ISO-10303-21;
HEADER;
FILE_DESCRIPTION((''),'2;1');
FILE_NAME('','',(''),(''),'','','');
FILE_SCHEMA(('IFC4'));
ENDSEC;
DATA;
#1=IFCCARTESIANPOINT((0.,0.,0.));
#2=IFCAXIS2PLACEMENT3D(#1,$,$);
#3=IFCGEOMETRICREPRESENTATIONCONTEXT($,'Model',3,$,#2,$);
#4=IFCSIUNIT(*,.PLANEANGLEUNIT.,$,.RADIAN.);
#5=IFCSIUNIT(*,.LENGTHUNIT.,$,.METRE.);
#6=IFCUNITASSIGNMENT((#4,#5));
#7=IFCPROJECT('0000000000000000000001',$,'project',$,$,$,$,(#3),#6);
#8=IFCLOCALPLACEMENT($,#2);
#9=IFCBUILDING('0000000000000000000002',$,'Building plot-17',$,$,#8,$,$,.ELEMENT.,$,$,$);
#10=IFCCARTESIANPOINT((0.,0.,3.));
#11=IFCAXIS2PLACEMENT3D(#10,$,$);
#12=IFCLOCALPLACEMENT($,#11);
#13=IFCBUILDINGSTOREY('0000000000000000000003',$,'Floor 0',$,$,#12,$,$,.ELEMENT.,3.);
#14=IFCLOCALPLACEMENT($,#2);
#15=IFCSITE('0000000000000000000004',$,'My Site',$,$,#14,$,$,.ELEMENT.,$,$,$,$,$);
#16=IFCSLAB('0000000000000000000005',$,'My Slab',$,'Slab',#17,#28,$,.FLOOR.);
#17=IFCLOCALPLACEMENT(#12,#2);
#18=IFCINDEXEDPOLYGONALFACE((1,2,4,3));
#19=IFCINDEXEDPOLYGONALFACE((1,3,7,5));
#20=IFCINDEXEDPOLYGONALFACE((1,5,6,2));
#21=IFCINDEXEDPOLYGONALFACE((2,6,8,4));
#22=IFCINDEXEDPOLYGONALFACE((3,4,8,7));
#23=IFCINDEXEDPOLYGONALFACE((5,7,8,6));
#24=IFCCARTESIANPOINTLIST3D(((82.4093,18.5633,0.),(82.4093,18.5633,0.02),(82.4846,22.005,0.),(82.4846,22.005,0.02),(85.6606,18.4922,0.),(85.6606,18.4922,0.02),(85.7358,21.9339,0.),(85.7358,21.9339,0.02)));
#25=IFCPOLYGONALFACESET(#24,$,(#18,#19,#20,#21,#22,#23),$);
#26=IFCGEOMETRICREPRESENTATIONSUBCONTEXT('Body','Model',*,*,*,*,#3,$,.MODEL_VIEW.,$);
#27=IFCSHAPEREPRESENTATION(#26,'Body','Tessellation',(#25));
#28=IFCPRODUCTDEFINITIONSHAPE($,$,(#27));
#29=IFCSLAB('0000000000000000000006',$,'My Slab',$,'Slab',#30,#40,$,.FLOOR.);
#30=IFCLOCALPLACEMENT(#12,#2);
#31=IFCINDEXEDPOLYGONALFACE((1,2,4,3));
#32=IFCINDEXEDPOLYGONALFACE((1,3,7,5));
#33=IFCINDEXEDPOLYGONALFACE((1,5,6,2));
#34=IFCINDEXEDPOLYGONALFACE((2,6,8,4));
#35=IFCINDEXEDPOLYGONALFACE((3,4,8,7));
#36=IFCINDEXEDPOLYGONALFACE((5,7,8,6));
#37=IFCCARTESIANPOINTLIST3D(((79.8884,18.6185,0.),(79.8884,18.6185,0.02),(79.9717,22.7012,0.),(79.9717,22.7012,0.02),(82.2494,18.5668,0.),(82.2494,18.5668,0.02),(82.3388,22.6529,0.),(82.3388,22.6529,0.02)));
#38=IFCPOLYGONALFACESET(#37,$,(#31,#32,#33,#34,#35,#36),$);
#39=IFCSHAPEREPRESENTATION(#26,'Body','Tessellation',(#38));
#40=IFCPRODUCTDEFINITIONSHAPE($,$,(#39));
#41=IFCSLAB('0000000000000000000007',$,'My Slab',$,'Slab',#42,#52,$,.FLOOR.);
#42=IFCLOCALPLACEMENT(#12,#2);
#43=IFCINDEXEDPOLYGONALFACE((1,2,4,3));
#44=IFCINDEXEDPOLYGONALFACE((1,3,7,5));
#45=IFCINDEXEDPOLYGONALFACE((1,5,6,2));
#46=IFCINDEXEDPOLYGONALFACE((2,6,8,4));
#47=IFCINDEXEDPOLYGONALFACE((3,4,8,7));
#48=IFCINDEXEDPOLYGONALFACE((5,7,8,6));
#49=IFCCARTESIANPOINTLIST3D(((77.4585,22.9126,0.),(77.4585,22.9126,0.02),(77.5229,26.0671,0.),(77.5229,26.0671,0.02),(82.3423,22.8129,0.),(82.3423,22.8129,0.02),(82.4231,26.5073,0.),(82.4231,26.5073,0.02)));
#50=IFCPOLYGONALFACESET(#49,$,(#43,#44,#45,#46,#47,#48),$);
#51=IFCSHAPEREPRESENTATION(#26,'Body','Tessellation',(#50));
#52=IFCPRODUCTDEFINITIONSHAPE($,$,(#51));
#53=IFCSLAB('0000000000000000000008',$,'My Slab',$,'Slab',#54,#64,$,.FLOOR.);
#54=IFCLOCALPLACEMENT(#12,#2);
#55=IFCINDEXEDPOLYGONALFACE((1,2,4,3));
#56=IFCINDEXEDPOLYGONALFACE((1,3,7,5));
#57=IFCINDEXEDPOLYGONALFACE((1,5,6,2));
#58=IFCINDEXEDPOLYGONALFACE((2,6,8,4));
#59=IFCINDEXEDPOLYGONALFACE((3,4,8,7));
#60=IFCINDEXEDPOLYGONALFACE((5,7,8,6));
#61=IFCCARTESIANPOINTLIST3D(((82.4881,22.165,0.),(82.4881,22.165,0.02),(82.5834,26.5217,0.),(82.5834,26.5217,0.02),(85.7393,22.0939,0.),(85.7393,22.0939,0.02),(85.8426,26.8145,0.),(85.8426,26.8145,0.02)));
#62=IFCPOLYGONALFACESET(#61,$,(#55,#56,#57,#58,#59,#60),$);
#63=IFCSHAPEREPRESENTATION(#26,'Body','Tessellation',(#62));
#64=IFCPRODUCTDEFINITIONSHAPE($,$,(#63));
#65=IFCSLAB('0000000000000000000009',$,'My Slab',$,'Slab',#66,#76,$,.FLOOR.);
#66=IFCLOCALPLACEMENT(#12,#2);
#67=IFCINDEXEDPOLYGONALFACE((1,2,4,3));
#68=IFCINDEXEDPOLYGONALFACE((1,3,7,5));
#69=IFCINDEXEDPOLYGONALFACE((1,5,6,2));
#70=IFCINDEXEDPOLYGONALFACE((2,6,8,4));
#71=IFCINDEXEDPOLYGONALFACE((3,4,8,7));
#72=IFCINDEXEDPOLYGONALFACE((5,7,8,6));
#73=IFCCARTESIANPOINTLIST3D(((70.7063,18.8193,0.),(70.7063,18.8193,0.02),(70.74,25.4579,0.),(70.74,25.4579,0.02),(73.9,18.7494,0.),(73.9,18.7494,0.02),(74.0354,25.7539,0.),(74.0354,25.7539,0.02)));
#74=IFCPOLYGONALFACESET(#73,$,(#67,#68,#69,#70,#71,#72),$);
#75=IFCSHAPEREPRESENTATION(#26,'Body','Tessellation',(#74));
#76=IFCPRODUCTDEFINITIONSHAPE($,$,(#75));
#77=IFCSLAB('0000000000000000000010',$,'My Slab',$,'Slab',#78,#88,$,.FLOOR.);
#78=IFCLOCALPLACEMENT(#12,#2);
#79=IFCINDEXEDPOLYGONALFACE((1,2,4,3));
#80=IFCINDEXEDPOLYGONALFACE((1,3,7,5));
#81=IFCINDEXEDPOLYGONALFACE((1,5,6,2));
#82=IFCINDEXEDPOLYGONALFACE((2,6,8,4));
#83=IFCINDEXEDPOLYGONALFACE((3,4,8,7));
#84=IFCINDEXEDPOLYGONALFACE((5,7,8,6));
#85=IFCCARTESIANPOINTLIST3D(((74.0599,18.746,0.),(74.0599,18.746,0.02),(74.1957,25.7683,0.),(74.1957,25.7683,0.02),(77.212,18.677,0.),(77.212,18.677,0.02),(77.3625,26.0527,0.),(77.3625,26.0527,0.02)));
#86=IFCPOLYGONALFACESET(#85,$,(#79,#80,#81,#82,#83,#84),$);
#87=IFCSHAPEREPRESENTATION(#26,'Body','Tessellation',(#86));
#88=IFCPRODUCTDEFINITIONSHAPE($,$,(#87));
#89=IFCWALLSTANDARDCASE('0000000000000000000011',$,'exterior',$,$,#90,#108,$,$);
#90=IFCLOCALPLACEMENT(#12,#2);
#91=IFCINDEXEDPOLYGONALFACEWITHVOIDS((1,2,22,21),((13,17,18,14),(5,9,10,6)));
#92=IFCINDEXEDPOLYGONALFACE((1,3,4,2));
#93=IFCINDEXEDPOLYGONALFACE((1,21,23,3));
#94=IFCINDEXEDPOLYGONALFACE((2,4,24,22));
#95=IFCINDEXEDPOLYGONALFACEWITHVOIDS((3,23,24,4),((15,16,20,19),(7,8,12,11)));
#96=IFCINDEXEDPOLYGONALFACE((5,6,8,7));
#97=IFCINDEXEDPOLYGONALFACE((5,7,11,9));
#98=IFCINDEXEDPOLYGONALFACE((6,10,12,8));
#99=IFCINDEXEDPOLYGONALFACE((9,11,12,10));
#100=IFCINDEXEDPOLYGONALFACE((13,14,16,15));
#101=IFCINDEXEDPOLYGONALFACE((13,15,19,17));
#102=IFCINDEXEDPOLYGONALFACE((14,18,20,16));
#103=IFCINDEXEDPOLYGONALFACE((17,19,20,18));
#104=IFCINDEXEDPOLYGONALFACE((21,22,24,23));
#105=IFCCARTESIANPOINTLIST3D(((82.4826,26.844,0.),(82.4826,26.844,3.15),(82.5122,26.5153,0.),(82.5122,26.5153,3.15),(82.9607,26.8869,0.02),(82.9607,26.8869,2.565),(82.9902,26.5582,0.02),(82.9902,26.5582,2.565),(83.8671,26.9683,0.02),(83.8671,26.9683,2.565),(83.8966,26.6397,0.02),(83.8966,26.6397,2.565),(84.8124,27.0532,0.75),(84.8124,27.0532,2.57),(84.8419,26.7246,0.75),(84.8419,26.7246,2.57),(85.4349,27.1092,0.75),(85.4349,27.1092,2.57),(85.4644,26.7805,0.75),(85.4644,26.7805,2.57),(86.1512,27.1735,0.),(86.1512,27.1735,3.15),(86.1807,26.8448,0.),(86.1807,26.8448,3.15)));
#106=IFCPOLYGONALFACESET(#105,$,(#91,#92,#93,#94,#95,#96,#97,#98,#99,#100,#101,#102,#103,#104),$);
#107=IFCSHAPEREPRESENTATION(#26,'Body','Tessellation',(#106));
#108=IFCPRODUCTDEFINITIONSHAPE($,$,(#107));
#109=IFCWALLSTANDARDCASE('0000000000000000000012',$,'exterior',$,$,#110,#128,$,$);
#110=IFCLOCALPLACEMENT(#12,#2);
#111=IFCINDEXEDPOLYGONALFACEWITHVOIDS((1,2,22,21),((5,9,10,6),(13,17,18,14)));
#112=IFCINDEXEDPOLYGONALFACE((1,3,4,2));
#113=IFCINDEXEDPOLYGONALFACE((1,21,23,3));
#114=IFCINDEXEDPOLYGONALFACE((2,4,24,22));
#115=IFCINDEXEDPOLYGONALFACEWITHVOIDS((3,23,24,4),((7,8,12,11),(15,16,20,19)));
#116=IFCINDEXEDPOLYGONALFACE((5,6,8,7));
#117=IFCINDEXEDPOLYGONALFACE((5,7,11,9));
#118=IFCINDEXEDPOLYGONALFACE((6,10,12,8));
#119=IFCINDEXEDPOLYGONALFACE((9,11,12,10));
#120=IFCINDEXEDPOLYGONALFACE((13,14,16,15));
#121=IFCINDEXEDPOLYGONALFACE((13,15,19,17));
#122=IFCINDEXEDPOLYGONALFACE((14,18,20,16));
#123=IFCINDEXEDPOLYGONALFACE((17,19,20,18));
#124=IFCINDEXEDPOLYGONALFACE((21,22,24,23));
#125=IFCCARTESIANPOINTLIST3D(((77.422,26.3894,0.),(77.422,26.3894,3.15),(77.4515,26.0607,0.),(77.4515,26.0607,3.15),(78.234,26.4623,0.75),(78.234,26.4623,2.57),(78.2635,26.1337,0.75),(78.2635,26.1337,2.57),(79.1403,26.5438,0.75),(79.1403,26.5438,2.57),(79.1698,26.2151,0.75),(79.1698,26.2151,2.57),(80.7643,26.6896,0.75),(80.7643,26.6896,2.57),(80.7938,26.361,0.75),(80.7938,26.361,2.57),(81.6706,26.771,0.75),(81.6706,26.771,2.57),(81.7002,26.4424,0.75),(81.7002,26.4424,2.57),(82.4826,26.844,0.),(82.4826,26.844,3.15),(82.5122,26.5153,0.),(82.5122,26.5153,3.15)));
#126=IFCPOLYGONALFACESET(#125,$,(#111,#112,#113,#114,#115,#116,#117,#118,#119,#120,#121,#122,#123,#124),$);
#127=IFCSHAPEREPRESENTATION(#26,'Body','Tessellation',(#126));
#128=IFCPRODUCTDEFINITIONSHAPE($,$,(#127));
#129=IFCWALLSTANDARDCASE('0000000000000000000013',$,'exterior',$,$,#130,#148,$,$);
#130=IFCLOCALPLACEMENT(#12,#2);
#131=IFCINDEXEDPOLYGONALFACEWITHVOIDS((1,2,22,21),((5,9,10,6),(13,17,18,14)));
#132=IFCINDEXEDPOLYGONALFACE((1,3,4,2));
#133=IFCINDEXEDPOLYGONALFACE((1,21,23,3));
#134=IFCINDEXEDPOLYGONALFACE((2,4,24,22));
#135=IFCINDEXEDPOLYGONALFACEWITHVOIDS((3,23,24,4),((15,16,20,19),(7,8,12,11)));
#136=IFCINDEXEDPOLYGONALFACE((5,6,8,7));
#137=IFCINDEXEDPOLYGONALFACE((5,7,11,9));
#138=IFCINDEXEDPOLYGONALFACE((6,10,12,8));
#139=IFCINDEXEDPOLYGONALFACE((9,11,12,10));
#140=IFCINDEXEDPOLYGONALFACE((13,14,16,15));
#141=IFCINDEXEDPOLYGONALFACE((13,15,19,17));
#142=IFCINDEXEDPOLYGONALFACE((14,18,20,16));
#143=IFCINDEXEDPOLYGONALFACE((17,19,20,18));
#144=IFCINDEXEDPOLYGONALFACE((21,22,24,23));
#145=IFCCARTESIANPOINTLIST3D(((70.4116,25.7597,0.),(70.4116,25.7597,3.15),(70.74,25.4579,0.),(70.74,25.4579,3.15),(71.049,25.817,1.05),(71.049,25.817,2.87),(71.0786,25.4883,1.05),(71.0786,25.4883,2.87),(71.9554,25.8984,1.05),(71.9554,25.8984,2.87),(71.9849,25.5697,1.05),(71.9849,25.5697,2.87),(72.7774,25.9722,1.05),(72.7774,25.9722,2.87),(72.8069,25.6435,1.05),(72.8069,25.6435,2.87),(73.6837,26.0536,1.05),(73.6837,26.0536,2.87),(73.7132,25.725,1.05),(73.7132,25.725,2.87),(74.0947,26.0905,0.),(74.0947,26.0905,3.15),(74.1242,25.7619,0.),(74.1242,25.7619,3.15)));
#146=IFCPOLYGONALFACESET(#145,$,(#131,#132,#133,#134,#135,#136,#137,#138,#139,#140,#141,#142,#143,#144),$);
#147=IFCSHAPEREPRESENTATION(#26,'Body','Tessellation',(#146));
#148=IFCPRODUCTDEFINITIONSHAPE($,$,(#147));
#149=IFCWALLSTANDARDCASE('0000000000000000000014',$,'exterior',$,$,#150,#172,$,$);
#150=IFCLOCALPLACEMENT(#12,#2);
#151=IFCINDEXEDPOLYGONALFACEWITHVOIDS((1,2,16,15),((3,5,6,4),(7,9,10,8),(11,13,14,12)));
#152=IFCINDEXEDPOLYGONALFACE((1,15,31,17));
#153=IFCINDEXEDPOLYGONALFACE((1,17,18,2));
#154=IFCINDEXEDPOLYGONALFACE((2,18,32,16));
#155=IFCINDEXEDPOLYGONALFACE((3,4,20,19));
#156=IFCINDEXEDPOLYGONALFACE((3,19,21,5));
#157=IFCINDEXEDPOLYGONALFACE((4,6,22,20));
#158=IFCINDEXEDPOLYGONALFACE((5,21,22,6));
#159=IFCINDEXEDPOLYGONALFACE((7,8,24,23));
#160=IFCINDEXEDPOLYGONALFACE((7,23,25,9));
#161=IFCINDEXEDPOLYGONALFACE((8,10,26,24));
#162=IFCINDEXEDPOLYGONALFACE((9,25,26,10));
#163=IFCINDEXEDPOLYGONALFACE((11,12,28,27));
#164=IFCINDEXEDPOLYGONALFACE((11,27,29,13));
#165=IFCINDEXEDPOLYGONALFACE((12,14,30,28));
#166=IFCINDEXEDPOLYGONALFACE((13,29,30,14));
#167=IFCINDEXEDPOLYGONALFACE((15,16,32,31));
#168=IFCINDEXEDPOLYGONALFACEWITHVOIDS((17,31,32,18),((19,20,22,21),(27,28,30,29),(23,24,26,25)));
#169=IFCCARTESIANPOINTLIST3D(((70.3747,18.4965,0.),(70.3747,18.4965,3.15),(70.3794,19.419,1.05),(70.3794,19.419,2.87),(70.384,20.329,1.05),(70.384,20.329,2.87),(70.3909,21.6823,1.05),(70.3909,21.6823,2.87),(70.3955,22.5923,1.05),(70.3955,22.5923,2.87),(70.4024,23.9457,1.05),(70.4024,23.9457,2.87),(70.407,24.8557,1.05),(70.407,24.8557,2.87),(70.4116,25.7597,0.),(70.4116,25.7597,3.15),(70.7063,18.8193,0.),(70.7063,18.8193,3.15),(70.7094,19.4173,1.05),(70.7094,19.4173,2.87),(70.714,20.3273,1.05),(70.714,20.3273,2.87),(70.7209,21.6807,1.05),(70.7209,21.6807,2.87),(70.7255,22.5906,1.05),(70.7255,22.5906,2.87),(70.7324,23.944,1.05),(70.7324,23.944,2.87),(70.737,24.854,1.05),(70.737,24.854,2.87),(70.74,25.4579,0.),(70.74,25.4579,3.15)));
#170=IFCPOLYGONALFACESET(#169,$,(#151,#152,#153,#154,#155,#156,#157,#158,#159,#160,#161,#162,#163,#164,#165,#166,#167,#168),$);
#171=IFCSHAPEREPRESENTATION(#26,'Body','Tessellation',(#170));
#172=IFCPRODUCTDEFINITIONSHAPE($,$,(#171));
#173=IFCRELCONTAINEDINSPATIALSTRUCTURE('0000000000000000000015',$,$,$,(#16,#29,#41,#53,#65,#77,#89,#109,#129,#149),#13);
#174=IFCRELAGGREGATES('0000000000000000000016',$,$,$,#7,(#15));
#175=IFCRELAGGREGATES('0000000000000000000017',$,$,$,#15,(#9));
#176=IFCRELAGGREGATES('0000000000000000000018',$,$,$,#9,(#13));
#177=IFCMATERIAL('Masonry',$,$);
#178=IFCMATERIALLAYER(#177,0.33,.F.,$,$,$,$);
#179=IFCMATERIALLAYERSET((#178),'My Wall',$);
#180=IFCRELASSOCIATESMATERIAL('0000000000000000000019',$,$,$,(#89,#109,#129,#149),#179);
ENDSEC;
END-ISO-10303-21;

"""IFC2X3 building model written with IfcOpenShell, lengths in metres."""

from ifc_helpers import new_model, si_unit, frame, origin, place, context, subcontext, project, spatial, polyline, outline, extrude, material, layer, layer_set, layer_usage, element, save


model = new_model("IFC2X3")

# Units and contexts
model_context = context("Model", 3, world=origin())
body_context = subcontext(model_context, "Body", "Model", "MODEL_VIEW")
ifc_project = project(units=[si_unit("PLANEANGLEUNIT", "RADIAN"), si_unit("LENGTHUNIT", "METRE")], contexts=[model_context])

# Site, building, storey
site_placement = place(None, origin())
site = spatial("IfcSite", under=ifc_project, at=site_placement, Name="My Site", CompositionType="ELEMENT")
building_placement = place(None, origin())
building = spatial("IfcBuilding", under=site, at=building_placement, Name="Building plot-17", CompositionType="ELEMENT")
storey_placement = place(None, frame((0.0, 0.0, 3.0)))
storey = spatial("IfcBuildingStorey", under=building, at=storey_placement, Name="Floor 0", CompositionType="ELEMENT", Elevation=3.0)

# Slabs
slab_1_placement = place(storey_placement, origin())
element("IfcSlab", 1, at=slab_1_placement, inside=storey, Name="My Slab", ObjectType="Slab", PredefinedType="FLOOR", context=body_context, shape_type="SweptSolid", body=[
    extrude(outline(polyline([(85.6606, 18.4922), (85.7358, 21.9339), (82.4846, 22.005), (82.4093, 18.5633), (85.6606, 18.4922)])), origin(), (0.0, 0.0, 1.0), 0.02),
])
slab_2_placement = place(storey_placement, origin())
element("IfcSlab", 2, at=slab_2_placement, inside=storey, Name="My Slab", ObjectType="Slab", PredefinedType="FLOOR", context=body_context, shape_type="SweptSolid", body=[
    extrude(outline(polyline([(79.8884, 18.6185), (82.2494, 18.5668), (82.3388, 22.6529), (79.9717, 22.7012), (79.8884, 18.6185)])), origin(), (0.0, 0.0, 1.0), 0.02),
])
slab_3_placement = place(storey_placement, origin())
element("IfcSlab", 3, at=slab_3_placement, inside=storey, Name="My Slab", ObjectType="Slab", PredefinedType="FLOOR", context=body_context, shape_type="SweptSolid", body=[
    extrude(outline(polyline([(82.3423, 22.8129), (82.4231, 26.5073), (77.5229, 26.0671), (77.4585, 22.9126), (82.3423, 22.8129)])), origin(), (0.0, 0.0, 1.0), 0.02),
])
slab_4_placement = place(storey_placement, origin())
element("IfcSlab", 4, at=slab_4_placement, inside=storey, Name="My Slab", ObjectType="Slab", PredefinedType="FLOOR", context=body_context, shape_type="SweptSolid", body=[
    extrude(outline(polyline([(85.7393, 22.0939), (85.8426, 26.8145), (82.5834, 26.5217), (82.4881, 22.165), (85.7393, 22.0939)])), origin(), (0.0, 0.0, 1.0), 0.02),
])
slab_5_placement = place(storey_placement, origin())
element("IfcSlab", 5, at=slab_5_placement, inside=storey, Name="My Slab", ObjectType="Slab", PredefinedType="FLOOR", context=body_context, shape_type="SweptSolid", body=[
    extrude(outline(polyline([(74.0354, 25.7539), (70.74, 25.4579), (70.7063, 18.8193), (73.9, 18.7494), (74.0354, 25.7539)])), origin(), (0.0, 0.0, 1.0), 0.02),
])
slab_6_placement = place(storey_placement, origin())
element("IfcSlab", 6, at=slab_6_placement, inside=storey, Name="My Slab", ObjectType="Slab", PredefinedType="FLOOR", context=body_context, shape_type="SweptSolid", body=[
    extrude(outline(polyline([(77.212, 18.677), (77.3625, 26.0527), (74.1957, 25.7683), (74.0599, 18.746), (77.212, 18.677)])), origin(), (0.0, 0.0, 1.0), 0.02),
])

# Walls, openings
ifc_material = material(Name="Masonry")
ifc_layer = layer(ifc_material, 0.33, ventilated=False)
ifc_layer_set = layer_set([ifc_layer], Name="My Wall")
ifc_layer_usage = layer_usage(ifc_layer_set, "AXIS2", "NEGATIVE", 0.08)
wall_1_placement = place(storey_placement, origin())
wall_1 = element("IfcWallStandardCase", 7, at=wall_1_placement, inside=storey, material=ifc_layer_usage, Name="exterior", context=body_context, shape_type="SweptSolid", body=[
    extrude(outline(polyline([(86.1807, 26.8448), (86.1512, 27.1735), (82.4826, 26.844), (82.5122, 26.5153), (86.1807, 26.8448)])), origin(), (0.0, 0.0, 1.0), 3.15),
])
opening_1_placement = place(storey_placement, frame((0.0, 0.0, 0.75)))
element("IfcOpeningElement", 8, at=opening_1_placement, cuts=wall_1, ObjectType="Opening", context=body_context, shape_type="SweptSolid", body=[
    extrude(outline(polyline([(85.4349, 27.1092), (84.8124, 27.0532), (84.8419, 26.7246), (85.4644, 26.7805), (85.4349, 27.1092)])), origin(), (0.0, 0.0, 1.0), 1.82),
])
opening_2_placement = place(storey_placement, frame((0.0, 0.0, 0.02)))
element("IfcOpeningElement", 9, at=opening_2_placement, cuts=wall_1, ObjectType="Opening", context=body_context, shape_type="SweptSolid", body=[
    extrude(outline(polyline([(83.8671, 26.9683), (82.9607, 26.8869), (82.9902, 26.5582), (83.8966, 26.6397), (83.8671, 26.9683)])), origin(), (0.0, 0.0, 1.0), 2.545),
])
wall_2_placement = place(storey_placement, origin())
wall_2 = element("IfcWallStandardCase", 10, at=wall_2_placement, inside=storey, material=ifc_layer_usage, Name="exterior", context=body_context, shape_type="SweptSolid", body=[
    extrude(outline(polyline([(82.5122, 26.5153), (82.4826, 26.844), (77.422, 26.3894), (77.4515, 26.0607), (82.5122, 26.5153)])), origin(), (0.0, 0.0, 1.0), 3.15),
])
opening_3_placement = place(storey_placement, frame((0.0, 0.0, 0.75)))
element("IfcOpeningElement", 11, at=opening_3_placement, cuts=wall_2, ObjectType="Opening", context=body_context, shape_type="SweptSolid", body=[
    extrude(outline(polyline([(81.6706, 26.771), (80.7643, 26.6896), (80.7938, 26.361), (81.7002, 26.4424), (81.6706, 26.771)])), origin(), (0.0, 0.0, 1.0), 1.82),
])
opening_4_placement = place(storey_placement, frame((0.0, 0.0, 0.75)))
element("IfcOpeningElement", 12, at=opening_4_placement, cuts=wall_2, ObjectType="Opening", context=body_context, shape_type="SweptSolid", body=[
    extrude(outline(polyline([(79.1403, 26.5438), (78.234, 26.4623), (78.2635, 26.1337), (79.1698, 26.2151), (79.1403, 26.5438)])), origin(), (0.0, 0.0, 1.0), 1.82),
])

# Walls, openings
wall_3_placement = place(storey_placement, origin())
wall_3 = element("IfcWallStandardCase", 13, at=wall_3_placement, inside=storey, material=ifc_layer_usage, Name="exterior", context=body_context, shape_type="SweptSolid", body=[
    extrude(outline(polyline([(74.1242, 25.7619), (74.0947, 26.0905), (70.4116, 25.7597), (70.74, 25.4579), (74.1242, 25.7619)])), origin(), (0.0, 0.0, 1.0), 3.15),
])
opening_5_placement = place(storey_placement, frame((0.0, 0.0, 1.05)))
element("IfcOpeningElement", 14, at=opening_5_placement, cuts=wall_3, ObjectType="Opening", context=body_context, shape_type="SweptSolid", body=[
    extrude(outline(polyline([(73.6837, 26.0536), (72.7774, 25.9722), (72.8069, 25.6435), (73.7132, 25.725), (73.6837, 26.0536)])), origin(), (0.0, 0.0, 1.0), 1.82),
])
opening_6_placement = place(storey_placement, frame((0.0, 0.0, 1.05)))
element("IfcOpeningElement", 15, at=opening_6_placement, cuts=wall_3, ObjectType="Opening", context=body_context, shape_type="SweptSolid", body=[
    extrude(outline(polyline([(71.9554, 25.8984), (71.049, 25.817), (71.0786, 25.4883), (71.9849, 25.5697), (71.9554, 25.8984)])), origin(), (0.0, 0.0, 1.0), 1.82),
])
wall_4_placement = place(storey_placement, origin())
wall_4 = element("IfcWallStandardCase", 16, at=wall_4_placement, inside=storey, material=ifc_layer_usage, Name="exterior", context=body_context, shape_type="SweptSolid", body=[
    extrude(outline(polyline([(70.74, 25.4579), (70.4116, 25.7597), (70.3747, 18.4965), (70.7063, 18.8193), (70.74, 25.4579)])), origin(), (0.0, 0.0, 1.0), 3.15),
])
opening_7_placement = place(storey_placement, frame((0.0, 0.0, 1.05)))
element("IfcOpeningElement", 17, at=opening_7_placement, cuts=wall_4, ObjectType="Opening", context=body_context, shape_type="SweptSolid", body=[
    extrude(outline(polyline([(70.407, 24.8557), (70.4024, 23.9457), (70.7324, 23.944), (70.737, 24.854), (70.407, 24.8557)])), origin(), (0.0, 0.0, 1.0), 1.82),
])
opening_8_placement = place(storey_placement, frame((0.0, 0.0, 1.05)))
element("IfcOpeningElement", 18, at=opening_8_placement, cuts=wall_4, ObjectType="Opening", context=body_context, shape_type="SweptSolid", body=[
    extrude(outline(polyline([(70.3955, 22.5923), (70.3909, 21.6823), (70.7209, 21.6807), (70.7255, 22.5906), (70.3955, 22.5923)])), origin(), (0.0, 0.0, 1.0), 1.82),
])
opening_9_placement = place(storey_placement, frame((0.0, 0.0, 1.05)))
element("IfcOpeningElement", 19, at=opening_9_placement, cuts=wall_4, ObjectType="Opening", context=body_context, shape_type="SweptSolid", body=[
    extrude(outline(polyline([(70.384, 20.329), (70.3794, 19.419), (70.7094, 19.4173), (70.714, 20.3273), (70.384, 20.329)])), origin(), (0.0, 0.0, 1.0), 1.82),
])

save(model, "model.ifc")
